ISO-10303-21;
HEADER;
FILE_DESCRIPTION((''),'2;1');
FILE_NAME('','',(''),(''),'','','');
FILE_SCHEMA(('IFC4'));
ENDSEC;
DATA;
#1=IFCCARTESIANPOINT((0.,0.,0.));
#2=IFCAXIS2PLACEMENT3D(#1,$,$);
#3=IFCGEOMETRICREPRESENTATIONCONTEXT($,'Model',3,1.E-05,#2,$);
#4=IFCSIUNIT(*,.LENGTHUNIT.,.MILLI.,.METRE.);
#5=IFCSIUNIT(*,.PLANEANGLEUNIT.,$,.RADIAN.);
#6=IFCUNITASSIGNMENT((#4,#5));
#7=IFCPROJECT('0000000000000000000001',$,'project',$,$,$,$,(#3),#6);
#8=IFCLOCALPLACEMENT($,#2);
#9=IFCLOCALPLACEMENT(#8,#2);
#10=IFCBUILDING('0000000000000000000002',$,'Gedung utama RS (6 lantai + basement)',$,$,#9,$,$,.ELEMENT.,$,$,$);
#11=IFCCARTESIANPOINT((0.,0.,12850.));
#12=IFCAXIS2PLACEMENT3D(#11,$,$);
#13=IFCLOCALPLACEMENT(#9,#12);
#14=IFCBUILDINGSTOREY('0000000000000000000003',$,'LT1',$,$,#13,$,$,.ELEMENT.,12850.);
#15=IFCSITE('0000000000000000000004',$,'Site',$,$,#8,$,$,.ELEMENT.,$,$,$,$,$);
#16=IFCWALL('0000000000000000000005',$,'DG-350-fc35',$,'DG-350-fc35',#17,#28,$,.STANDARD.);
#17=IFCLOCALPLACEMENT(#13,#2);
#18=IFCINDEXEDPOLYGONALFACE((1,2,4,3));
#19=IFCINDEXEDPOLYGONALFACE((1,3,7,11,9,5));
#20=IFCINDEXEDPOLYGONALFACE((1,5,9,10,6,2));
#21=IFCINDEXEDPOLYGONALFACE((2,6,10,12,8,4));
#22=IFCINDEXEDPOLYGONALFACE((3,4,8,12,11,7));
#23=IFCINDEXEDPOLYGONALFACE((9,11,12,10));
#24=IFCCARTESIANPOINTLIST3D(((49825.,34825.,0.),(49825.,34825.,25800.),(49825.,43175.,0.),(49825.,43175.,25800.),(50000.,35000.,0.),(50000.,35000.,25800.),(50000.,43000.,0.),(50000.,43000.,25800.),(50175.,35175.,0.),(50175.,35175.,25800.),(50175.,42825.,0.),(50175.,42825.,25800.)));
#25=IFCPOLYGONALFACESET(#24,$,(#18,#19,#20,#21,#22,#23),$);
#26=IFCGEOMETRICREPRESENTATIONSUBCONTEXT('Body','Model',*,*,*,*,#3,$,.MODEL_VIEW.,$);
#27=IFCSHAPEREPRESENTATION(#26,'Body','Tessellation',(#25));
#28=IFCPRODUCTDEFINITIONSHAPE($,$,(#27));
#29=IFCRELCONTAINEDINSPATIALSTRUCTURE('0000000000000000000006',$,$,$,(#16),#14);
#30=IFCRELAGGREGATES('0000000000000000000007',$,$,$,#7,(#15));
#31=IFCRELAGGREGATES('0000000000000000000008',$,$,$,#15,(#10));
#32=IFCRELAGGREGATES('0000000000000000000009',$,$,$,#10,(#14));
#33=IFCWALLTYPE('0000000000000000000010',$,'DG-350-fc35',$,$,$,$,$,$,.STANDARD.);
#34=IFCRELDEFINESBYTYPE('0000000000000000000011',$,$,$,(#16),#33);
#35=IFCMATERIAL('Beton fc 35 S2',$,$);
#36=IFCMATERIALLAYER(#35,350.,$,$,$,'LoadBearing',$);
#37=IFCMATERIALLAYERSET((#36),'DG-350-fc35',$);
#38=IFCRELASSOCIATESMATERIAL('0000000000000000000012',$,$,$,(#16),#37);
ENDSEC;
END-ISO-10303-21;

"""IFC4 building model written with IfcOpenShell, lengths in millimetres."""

from ifc_helpers import new_model, si_unit, frame, origin, place, context, subcontext, project, spatial, polyline, outline, extrude, material, layer, layer_set, layer_usage, type_object, element, save


model = new_model("IFC4")

# Units and contexts
model_context = context("Model", 3, precision=1e-05, world=origin())
body_context = subcontext(model_context, "Body", "Model", "MODEL_VIEW")
ifc_project = project(units=[si_unit("LENGTHUNIT", "METRE", prefix="MILLI"), si_unit("PLANEANGLEUNIT", "RADIAN")], contexts=[model_context])

# Site, building, storey
site_placement = place(None, origin())
site = spatial("IfcSite", under=ifc_project, at=site_placement, Name="Site", CompositionType="ELEMENT")
building_placement = place(site_placement, origin())
building = spatial("IfcBuilding", under=site, at=building_placement, Name="Gedung utama RS (6 lantai + basement)", CompositionType="ELEMENT")
storey_placement = place(building_placement, frame((0.0, 0.0, 12850.0)))
storey = spatial("IfcBuildingStorey", under=building, at=storey_placement, Name="LT1", CompositionType="ELEMENT", Elevation=12850.0)

# Wall
ifc_material_1 = material(Name="Beton fc 35 S2")
ifc_layer = layer(ifc_material_1, 350.0, Category="LoadBearing")
ifc_layer_set = layer_set([ifc_layer], Name="DG-350-fc35")
ifc_layer_usage = layer_usage(ifc_layer_set, "AXIS2", "NEGATIVE", 175.0)
wall_type = type_object("IfcWallType", Name="DG-350-fc35", PredefinedType="STANDARD")
for number, where, z_axis, x_axis, name in (
    (1, (50000.0, 43000.0, 0.0), (0.0, 0.0, 1.0), (0.0, -1.0, 0.0), "DG-350-fc35"),
):
    element("IfcWall", number, at=place(storey_placement, frame(where, z_axis=z_axis, x_axis=x_axis)), inside=storey, type_object=wall_type, material=ifc_layer_usage, Name=name, ObjectType="DG-350-fc35", PredefinedType="STANDARD", context=body_context, shape_type="SweptSolid", body=[
        extrude(outline(polyline([(-175.0, -175.0), (0.0, 0.0), (175.0, 175.0), (7825.0, 175.0), (8000.0, 0.0), (8175.0, -175.0), (-175.0, -175.0)])), origin(), (0.0, 0.0, 1.0), 25800.0),
    ])

save(model, "model.ifc")
